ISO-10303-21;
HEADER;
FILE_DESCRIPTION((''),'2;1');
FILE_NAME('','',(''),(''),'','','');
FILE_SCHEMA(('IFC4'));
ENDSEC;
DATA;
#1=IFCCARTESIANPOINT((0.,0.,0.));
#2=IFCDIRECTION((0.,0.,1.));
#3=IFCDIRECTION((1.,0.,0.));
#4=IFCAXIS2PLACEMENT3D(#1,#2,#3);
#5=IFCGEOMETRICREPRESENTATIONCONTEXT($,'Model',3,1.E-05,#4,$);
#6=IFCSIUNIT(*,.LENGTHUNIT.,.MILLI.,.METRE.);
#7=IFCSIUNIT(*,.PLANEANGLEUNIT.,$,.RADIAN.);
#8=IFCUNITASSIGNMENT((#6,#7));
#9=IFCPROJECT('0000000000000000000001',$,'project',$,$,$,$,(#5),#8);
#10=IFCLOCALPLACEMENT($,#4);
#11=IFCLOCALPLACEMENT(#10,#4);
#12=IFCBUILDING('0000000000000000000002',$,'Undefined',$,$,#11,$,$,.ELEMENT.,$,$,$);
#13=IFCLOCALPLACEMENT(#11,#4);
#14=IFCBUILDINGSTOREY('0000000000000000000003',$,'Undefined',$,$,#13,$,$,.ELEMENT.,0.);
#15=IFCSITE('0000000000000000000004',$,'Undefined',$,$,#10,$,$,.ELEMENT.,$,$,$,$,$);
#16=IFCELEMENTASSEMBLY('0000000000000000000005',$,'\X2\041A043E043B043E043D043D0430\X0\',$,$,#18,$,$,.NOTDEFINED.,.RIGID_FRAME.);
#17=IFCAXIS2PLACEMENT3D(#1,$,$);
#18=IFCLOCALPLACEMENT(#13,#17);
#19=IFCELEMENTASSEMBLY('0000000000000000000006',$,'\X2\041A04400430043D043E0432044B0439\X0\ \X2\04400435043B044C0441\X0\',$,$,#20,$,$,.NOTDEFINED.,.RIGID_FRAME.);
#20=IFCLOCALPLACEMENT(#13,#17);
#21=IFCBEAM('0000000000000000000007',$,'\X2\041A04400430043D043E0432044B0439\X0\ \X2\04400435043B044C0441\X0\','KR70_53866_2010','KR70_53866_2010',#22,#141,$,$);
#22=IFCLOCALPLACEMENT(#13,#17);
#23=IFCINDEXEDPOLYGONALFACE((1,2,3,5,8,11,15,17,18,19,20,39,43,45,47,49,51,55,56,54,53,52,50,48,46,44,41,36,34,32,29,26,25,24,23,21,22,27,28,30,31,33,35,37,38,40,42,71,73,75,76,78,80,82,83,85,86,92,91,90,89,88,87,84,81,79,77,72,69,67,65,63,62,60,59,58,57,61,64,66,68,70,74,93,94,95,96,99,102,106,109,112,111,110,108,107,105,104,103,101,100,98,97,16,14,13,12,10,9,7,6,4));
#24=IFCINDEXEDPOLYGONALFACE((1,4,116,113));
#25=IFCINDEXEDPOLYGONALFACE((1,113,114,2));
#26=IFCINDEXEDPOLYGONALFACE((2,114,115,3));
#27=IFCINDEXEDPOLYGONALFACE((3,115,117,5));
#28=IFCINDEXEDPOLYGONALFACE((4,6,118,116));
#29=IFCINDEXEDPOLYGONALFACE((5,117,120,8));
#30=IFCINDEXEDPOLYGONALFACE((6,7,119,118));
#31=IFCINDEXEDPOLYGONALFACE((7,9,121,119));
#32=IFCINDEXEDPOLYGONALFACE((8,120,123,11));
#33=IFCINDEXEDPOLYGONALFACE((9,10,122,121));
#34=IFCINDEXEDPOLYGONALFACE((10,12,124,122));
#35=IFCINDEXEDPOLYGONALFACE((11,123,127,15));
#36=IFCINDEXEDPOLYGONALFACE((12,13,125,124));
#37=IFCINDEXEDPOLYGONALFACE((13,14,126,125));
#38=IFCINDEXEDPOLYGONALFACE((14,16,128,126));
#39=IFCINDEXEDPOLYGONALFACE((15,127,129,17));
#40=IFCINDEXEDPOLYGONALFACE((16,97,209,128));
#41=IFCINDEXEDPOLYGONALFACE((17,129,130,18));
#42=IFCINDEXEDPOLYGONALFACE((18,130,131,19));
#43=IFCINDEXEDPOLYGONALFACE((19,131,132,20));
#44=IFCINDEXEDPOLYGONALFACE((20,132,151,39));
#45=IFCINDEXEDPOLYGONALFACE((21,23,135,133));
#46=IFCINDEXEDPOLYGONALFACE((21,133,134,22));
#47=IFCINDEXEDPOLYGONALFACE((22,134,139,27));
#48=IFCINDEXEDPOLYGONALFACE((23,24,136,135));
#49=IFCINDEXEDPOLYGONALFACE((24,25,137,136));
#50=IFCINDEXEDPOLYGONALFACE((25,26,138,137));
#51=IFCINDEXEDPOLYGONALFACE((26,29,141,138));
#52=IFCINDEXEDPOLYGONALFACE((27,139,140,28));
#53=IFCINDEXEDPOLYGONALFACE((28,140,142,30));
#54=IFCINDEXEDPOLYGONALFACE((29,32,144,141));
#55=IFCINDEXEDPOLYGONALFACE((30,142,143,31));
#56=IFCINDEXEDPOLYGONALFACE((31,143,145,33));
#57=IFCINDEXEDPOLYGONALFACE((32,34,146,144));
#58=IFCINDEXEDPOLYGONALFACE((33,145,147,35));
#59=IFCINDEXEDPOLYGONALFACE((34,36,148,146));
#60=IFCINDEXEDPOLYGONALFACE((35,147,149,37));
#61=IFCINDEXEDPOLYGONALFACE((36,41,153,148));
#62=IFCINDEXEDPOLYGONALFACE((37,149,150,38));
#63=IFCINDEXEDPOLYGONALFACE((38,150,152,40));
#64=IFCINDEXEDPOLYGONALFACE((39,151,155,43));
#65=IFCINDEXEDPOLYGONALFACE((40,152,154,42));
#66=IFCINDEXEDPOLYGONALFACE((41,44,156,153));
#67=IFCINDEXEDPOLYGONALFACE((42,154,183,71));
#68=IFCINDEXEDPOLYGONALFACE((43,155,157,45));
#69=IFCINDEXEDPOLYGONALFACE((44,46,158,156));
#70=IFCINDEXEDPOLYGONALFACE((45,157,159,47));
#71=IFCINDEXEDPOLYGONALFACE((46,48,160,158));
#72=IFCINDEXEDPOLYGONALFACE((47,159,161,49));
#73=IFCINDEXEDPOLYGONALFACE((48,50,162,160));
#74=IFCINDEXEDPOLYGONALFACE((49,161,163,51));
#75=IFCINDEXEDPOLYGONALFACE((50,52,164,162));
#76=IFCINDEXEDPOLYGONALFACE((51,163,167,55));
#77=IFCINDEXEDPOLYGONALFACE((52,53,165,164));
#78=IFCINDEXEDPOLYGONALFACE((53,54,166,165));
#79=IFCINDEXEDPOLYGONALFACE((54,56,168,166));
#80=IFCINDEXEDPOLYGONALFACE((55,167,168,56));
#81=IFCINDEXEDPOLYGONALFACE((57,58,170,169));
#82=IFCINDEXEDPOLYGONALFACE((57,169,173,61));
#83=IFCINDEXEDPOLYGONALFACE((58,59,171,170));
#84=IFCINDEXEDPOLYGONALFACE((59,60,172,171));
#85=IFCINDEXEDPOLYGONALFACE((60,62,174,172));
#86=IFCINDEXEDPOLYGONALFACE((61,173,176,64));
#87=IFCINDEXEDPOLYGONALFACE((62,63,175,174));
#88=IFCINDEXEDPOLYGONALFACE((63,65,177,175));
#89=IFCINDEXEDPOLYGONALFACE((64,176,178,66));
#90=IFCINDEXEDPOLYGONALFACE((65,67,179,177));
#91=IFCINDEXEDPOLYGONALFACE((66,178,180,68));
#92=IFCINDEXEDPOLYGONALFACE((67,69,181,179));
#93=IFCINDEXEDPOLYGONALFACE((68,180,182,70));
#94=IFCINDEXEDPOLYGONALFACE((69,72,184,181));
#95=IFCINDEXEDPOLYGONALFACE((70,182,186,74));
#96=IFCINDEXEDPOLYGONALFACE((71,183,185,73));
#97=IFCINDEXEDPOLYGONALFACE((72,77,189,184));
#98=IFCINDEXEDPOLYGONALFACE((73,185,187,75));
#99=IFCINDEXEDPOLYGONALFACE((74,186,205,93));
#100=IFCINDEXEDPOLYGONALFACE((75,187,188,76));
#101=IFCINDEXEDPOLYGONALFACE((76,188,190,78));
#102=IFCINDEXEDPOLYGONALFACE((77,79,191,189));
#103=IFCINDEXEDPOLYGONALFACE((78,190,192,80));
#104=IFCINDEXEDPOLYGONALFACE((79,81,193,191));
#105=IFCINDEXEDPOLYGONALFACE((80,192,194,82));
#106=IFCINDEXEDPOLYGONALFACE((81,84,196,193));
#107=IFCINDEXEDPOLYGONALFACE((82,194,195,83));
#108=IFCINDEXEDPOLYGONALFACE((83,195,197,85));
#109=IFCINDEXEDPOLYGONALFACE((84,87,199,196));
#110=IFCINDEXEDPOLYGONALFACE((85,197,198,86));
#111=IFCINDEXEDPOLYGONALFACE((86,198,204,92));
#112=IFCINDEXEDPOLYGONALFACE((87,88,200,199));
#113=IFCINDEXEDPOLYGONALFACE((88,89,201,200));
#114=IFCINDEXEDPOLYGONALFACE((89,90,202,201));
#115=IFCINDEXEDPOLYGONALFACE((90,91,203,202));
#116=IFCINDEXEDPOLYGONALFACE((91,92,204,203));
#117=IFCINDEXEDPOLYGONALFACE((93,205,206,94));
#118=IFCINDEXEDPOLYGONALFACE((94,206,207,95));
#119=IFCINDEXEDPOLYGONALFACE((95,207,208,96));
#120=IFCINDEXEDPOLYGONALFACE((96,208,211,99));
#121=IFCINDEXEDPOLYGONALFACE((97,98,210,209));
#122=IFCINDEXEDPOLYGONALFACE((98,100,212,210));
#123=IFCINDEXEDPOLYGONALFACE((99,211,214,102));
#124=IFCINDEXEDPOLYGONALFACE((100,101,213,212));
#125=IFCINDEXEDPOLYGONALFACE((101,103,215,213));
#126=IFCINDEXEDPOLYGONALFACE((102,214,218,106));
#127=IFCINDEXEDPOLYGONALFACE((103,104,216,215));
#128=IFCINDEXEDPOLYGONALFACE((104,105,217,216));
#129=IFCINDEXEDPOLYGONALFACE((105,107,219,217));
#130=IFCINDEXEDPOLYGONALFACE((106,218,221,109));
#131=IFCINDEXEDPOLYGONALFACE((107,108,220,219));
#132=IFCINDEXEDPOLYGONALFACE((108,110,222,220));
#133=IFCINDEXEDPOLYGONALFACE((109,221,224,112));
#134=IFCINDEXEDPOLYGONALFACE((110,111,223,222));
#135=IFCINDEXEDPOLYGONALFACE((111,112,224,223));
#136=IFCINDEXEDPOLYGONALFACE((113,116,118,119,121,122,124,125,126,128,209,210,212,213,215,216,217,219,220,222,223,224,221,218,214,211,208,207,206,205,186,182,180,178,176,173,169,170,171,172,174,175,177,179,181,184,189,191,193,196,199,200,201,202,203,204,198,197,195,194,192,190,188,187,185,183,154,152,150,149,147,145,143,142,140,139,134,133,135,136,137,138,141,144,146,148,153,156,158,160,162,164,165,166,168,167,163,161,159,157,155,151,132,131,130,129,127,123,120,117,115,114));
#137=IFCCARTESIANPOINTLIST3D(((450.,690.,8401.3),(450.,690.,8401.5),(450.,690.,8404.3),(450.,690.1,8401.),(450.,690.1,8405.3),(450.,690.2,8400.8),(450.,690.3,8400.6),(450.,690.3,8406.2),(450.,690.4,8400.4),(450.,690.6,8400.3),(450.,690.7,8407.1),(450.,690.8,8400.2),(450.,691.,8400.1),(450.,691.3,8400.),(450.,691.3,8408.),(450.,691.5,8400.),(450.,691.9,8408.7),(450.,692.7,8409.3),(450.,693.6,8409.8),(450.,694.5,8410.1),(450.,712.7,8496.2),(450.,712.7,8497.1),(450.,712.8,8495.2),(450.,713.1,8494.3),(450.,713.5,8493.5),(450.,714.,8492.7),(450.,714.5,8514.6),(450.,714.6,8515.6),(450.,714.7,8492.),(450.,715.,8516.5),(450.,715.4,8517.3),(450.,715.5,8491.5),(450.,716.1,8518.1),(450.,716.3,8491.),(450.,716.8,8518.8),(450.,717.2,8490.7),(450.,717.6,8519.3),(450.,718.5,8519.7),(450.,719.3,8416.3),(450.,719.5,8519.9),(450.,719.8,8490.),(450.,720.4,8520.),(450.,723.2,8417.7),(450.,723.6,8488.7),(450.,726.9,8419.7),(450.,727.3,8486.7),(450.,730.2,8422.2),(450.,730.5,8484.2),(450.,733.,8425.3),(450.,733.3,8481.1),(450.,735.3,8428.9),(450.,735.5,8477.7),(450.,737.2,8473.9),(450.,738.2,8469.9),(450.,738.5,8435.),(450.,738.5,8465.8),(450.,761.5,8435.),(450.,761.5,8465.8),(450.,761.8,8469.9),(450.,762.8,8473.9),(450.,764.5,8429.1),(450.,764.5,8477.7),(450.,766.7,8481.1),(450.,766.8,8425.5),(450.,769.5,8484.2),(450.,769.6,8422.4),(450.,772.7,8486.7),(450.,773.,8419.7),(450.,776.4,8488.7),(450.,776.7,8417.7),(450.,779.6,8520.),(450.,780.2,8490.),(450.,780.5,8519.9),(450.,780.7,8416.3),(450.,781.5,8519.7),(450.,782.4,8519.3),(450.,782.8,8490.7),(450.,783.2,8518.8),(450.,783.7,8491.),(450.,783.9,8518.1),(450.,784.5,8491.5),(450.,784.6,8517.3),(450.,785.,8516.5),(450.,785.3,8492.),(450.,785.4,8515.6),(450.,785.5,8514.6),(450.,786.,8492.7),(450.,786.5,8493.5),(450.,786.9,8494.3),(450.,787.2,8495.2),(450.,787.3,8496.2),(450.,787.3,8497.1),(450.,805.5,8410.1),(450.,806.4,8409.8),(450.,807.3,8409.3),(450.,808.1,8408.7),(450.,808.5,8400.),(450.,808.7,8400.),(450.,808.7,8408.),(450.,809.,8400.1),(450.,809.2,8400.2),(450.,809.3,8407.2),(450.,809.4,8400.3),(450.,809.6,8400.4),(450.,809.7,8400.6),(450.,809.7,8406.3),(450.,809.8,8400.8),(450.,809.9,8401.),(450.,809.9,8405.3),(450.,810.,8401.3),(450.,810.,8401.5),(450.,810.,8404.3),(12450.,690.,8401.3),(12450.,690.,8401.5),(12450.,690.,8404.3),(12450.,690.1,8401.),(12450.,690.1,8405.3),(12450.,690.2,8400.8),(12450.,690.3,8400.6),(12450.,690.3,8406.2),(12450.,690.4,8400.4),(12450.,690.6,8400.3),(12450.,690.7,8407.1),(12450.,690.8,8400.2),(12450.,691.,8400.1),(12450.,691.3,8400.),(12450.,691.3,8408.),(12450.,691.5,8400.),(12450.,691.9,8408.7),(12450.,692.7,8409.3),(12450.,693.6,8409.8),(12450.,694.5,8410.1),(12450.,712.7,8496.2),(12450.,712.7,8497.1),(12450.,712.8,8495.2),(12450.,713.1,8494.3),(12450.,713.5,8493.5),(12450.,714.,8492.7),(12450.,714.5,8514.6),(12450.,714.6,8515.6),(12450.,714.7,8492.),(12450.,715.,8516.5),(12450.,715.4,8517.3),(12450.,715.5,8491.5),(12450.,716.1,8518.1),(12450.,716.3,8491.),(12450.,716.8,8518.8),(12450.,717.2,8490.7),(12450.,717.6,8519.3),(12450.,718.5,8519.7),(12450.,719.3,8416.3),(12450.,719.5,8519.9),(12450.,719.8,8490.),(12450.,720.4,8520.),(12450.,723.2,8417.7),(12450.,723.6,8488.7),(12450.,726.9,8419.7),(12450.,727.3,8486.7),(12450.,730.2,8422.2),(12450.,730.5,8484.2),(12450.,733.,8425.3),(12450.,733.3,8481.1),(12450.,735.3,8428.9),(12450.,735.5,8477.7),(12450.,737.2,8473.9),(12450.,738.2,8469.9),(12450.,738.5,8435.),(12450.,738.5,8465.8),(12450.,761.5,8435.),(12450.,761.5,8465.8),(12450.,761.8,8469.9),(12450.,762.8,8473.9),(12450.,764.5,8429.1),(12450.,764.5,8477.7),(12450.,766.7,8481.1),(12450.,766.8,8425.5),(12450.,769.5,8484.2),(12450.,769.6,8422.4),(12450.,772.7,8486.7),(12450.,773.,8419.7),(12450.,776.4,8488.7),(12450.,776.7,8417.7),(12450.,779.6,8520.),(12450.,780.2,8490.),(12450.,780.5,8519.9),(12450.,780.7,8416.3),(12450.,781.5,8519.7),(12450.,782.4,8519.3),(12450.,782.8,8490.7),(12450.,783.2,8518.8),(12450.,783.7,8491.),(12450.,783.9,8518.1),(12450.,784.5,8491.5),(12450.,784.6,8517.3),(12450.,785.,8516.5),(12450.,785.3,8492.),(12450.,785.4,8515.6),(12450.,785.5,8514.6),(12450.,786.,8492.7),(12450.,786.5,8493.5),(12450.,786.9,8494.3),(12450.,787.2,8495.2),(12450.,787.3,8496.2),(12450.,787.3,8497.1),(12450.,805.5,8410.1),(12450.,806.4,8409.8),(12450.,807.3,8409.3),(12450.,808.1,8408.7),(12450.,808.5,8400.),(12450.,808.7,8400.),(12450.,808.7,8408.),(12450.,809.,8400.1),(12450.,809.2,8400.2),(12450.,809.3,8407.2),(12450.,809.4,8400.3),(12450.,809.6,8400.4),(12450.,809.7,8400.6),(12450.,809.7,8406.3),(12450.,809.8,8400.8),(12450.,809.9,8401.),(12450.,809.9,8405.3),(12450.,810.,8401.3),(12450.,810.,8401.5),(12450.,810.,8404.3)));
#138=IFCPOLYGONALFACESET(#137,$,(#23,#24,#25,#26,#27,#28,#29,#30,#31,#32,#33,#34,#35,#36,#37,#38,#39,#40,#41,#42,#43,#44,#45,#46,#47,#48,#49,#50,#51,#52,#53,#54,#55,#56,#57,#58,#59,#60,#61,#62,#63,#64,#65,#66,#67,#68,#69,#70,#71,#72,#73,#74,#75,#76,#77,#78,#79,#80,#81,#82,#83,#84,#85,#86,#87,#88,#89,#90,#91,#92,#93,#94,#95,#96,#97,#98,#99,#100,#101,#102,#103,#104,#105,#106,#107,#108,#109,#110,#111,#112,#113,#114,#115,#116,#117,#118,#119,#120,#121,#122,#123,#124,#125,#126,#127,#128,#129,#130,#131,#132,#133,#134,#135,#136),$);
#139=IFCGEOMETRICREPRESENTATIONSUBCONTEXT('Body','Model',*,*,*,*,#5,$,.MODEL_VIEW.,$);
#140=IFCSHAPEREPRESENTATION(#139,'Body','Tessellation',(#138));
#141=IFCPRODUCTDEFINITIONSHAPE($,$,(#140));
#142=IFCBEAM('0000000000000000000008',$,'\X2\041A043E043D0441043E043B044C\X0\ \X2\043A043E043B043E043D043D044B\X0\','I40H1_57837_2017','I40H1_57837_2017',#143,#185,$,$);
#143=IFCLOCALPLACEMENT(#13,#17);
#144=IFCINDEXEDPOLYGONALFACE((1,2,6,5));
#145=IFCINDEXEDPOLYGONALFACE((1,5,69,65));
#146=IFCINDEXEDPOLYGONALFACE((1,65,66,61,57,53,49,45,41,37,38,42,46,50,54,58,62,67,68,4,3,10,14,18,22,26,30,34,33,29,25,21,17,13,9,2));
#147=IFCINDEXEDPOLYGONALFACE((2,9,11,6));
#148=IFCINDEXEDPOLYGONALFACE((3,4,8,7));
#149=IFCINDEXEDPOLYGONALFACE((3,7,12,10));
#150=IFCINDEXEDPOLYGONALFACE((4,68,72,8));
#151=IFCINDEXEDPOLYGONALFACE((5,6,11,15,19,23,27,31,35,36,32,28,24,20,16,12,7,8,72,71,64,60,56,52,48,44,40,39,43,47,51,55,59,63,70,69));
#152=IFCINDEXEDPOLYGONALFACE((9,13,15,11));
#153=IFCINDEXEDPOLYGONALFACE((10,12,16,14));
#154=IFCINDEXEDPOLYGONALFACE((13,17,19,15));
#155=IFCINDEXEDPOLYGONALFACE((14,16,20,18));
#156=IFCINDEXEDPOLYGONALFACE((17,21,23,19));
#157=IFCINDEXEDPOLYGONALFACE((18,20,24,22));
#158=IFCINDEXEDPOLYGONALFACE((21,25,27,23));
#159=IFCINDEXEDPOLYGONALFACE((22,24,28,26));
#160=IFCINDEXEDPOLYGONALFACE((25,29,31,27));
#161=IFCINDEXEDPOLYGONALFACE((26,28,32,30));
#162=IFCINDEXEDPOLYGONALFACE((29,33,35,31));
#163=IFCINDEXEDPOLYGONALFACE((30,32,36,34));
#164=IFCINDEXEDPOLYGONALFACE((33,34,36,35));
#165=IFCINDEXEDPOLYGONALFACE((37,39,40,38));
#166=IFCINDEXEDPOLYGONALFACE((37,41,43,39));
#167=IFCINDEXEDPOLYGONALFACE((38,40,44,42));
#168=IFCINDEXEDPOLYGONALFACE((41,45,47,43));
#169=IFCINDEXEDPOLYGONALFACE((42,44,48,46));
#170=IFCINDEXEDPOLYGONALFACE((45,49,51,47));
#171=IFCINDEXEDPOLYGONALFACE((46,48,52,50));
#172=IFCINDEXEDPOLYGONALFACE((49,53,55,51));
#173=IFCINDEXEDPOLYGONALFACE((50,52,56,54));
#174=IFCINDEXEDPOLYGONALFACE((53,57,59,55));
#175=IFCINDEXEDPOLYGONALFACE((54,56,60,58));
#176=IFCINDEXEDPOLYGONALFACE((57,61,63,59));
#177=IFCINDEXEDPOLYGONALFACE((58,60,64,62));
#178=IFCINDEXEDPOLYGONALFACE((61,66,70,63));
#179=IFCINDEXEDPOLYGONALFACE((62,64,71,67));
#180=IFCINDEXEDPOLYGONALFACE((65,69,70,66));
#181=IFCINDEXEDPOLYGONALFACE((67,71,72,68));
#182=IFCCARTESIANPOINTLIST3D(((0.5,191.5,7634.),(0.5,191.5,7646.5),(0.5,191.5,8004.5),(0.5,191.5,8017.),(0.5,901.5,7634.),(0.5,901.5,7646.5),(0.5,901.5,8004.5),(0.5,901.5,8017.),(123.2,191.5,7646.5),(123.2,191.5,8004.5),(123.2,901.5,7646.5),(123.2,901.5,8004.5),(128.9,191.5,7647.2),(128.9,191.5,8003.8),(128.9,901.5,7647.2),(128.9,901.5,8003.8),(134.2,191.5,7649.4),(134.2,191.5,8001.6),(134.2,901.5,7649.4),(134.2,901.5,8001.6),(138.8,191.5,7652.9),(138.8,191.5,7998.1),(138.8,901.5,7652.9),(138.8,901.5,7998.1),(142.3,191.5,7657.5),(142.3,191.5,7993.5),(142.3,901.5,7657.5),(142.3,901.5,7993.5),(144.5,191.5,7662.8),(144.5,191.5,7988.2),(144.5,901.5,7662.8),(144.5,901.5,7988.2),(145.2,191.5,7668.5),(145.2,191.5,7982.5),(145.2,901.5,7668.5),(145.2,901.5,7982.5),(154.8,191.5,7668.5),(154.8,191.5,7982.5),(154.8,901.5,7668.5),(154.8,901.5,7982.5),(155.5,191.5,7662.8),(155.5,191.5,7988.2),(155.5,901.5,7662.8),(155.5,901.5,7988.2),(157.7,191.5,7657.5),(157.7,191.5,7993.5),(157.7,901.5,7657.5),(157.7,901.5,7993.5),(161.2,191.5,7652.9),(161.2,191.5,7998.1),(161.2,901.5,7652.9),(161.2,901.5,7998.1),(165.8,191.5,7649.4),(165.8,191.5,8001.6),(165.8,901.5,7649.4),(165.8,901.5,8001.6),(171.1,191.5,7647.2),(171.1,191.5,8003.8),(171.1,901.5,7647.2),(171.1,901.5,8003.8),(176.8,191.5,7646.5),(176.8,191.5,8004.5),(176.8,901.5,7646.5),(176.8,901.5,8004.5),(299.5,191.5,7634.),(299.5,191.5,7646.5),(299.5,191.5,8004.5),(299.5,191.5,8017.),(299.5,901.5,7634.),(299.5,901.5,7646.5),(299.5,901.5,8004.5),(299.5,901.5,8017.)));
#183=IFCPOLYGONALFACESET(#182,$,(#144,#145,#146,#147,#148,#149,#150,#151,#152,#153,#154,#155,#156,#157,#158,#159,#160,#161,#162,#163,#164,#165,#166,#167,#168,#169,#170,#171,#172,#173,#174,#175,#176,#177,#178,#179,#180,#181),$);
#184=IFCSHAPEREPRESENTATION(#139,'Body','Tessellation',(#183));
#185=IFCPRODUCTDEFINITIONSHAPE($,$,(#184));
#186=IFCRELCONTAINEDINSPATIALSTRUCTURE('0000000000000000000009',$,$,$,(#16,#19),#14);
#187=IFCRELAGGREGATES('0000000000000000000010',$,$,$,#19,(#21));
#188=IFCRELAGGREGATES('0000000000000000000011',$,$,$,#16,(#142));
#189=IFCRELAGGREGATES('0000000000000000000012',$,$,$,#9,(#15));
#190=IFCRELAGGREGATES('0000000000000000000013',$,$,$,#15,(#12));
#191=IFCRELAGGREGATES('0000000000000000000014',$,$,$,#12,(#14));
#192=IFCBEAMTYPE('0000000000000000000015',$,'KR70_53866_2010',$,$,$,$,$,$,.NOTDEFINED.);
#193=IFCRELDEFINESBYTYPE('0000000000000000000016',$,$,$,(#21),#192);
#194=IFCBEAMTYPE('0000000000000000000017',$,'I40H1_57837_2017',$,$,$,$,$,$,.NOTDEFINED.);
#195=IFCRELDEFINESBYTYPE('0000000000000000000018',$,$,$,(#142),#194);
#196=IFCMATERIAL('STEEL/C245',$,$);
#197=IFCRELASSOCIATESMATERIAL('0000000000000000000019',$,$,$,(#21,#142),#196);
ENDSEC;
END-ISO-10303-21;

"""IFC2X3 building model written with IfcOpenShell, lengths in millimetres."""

from ifc_helpers import new_model, si_unit, frame, origin_with_axes, origin_2d_with_axis, place, context, subcontext, project, spatial, polyline, i_section, outline, extrude, material, type_object, element, aggregate, save


model = new_model("IFC2X3")

# Units and contexts
model_context = context("Model", 3, precision=1e-05, world=origin_with_axes())
body_context = subcontext(model_context, "Body", "Model", "MODEL_VIEW")
ifc_project = project(units=[si_unit("LENGTHUNIT", "METRE", prefix="MILLI"), si_unit("PLANEANGLEUNIT", "RADIAN")], contexts=[model_context])

# Site, building, storey
site_placement = place(None, origin_with_axes())
site = spatial("IfcSite", under=ifc_project, at=site_placement, Name="Undefined", CompositionType="ELEMENT")
building_placement = place(site_placement, origin_with_axes())
building = spatial("IfcBuilding", under=site, at=building_placement, Name="Undefined", CompositionType="ELEMENT")
storey_placement = place(building_placement, origin_with_axes())
storey = spatial("IfcBuildingStorey", under=building, at=storey_placement, Name="Undefined", CompositionType="ELEMENT", Elevation=0.0)

# Element assembly
ifc_material_1 = material(Name="STEEL/C245")
assembly_1_placement = place(storey_placement, origin_with_axes())
assembly_1 = element("IfcElementAssembly", 1, at=assembly_1_placement, inside=storey, Name="Колонна", AssemblyPlace="NOTDEFINED", PredefinedType="RIGID_FRAME")

# Element assembly, beam
assembly_2_placement = place(storey_placement, origin_with_axes())
assembly_2 = element("IfcElementAssembly", 2, at=assembly_2_placement, inside=storey, Name="Крановый рельс", AssemblyPlace="NOTDEFINED", PredefinedType="RIGID_FRAME")
beam_type_1 = type_object("IfcBeamType", Name="KR70_53866_2010", PredefinedType="NOTDEFINED")
beam_1_placement = place(assembly_2_placement, frame((450.0, 750.0, 8460.0), z_axis=(0.0, 0.0, 1.0), x_axis=(1.0, 0.0, 0.0)))
beam_1 = element("IfcBeam", 3, at=beam_1_placement, type_object=beam_type_1, material=ifc_material_1, Name="Крановый рельс", Description="KR70_53866_2010", ObjectType="KR70_53866_2010", context=body_context, shape_type="SweptSolid", body=[
    extrude(outline(polyline([(58.7, -52.0), (59.3, -52.9), (59.7, -53.8), (59.9, -54.7), (60.0, -55.7), (60.0, -58.5), (60.0, -58.7), (59.9, -59.0), (59.8, -59.2), (59.7, -59.4), (59.6, -59.6), (59.4, -59.7), (59.2, -59.8), (59.0, -59.9), (58.7, -60.0), (58.5, -60.0), (-58.5, -60.0), (-58.7, -60.0), (-59.0, -59.9), (-59.2, -59.8), (-59.4, -59.7), (-59.6, -59.6), (-59.7, -59.4), (-59.8, -59.2), (-59.9, -59.0), (-60.0, -58.7), (-60.0, -58.5), (-60.0, -55.7), (-59.9, -54.7), (-59.7, -53.7), (-59.3, -52.8), (-58.7, -52.0), (-58.1, -51.3), (-57.3, -50.7), (-56.4, -50.2), (-55.5, -49.9), (-30.7, -43.7), (-26.7, -42.3), (-23.0, -40.3), (-19.6, -37.6), (-16.8, -34.5), (-14.5, -30.9), (-11.5, -25.0), (-11.5, 5.8), (-11.8, 9.9), (-12.8, 13.9), (-14.5, 17.7), (-16.7, 21.1), (-19.5, 24.2), (-22.7, 26.7), (-26.4, 28.7), (-30.2, 30.0), (-32.8, 30.7), (-33.7, 31.0), (-34.5, 31.5), (-35.3, 32.0), (-36.0, 32.7), (-36.5, 33.5), (-36.9, 34.3), (-37.2, 35.2), (-37.3, 36.2), (-37.3, 37.1), (-35.5, 54.6), (-35.4, 55.6), (-35.0, 56.5), (-34.6, 57.3), (-33.9, 58.1), (-33.2, 58.8), (-32.4, 59.3), (-31.5, 59.7), (-30.5, 59.9), (-29.6, 60.0), (29.6, 60.0), (30.5, 59.9), (31.5, 59.7), (32.4, 59.3), (33.2, 58.8), (33.9, 58.1), (34.6, 57.3), (35.0, 56.5), (35.4, 55.6), (35.5, 54.6), (37.3, 37.1), (37.3, 36.2), (37.2, 35.2), (36.9, 34.3), (36.5, 33.5), (36.0, 32.7), (35.3, 32.0), (34.5, 31.5), (33.7, 31.0), (32.8, 30.7), (30.2, 30.0), (26.4, 28.7), (22.7, 26.7), (19.5, 24.2), (16.7, 21.1), (14.5, 17.7), (12.8, 13.9), (11.8, 9.9), (11.5, 5.8), (11.5, -25.0), (14.7, -31.1), (17.0, -34.7), (19.8, -37.8), (23.1, -40.3), (26.8, -42.3), (30.7, -43.7), (55.5, -49.9), (56.4, -50.2), (57.3, -50.7), (58.1, -51.3), (58.7, -52.0)])), frame((12000.0, 0.0, 0.0), z_axis=(-1.0, 0.0, 0.0), x_axis=(0.0, -1.0, 0.0)), (0.0, 0.0, 1.0), 12000.0),
])
aggregate(assembly_2, [beam_1])

# Beam
beam_type_2 = type_object("IfcBeamType", Name="I40H1_57837_2017", PredefinedType="NOTDEFINED")
beam_2_placement = place(assembly_1_placement, frame((150.0, 901.5, 7825.5), z_axis=(0.0, 0.0, 1.0), x_axis=(0.0, -1.0, 0.0)))
beam_2 = element("IfcBeam", 4, at=beam_2_placement, type_object=beam_type_2, material=ifc_material_1, Name="Консоль колонны", Description="I40H1_57837_2017", ObjectType="I40H1_57837_2017", context=body_context, shape_type="SweptSolid", body=[
    extrude(i_section(OverallWidth=299.0, OverallDepth=383.0, WebThickness=9.5, FlangeThickness=12.5, FilletRadius=22.0, at=origin_2d_with_axis()), frame((710.0, 0.0, 0.0), z_axis=(-1.0, 0.0, 0.0), x_axis=(0.0, -1.0, 0.0)), (0.0, 0.0, 1.0), 710.0),
])
aggregate(assembly_1, [beam_2])

save(model, "model.ifc")
